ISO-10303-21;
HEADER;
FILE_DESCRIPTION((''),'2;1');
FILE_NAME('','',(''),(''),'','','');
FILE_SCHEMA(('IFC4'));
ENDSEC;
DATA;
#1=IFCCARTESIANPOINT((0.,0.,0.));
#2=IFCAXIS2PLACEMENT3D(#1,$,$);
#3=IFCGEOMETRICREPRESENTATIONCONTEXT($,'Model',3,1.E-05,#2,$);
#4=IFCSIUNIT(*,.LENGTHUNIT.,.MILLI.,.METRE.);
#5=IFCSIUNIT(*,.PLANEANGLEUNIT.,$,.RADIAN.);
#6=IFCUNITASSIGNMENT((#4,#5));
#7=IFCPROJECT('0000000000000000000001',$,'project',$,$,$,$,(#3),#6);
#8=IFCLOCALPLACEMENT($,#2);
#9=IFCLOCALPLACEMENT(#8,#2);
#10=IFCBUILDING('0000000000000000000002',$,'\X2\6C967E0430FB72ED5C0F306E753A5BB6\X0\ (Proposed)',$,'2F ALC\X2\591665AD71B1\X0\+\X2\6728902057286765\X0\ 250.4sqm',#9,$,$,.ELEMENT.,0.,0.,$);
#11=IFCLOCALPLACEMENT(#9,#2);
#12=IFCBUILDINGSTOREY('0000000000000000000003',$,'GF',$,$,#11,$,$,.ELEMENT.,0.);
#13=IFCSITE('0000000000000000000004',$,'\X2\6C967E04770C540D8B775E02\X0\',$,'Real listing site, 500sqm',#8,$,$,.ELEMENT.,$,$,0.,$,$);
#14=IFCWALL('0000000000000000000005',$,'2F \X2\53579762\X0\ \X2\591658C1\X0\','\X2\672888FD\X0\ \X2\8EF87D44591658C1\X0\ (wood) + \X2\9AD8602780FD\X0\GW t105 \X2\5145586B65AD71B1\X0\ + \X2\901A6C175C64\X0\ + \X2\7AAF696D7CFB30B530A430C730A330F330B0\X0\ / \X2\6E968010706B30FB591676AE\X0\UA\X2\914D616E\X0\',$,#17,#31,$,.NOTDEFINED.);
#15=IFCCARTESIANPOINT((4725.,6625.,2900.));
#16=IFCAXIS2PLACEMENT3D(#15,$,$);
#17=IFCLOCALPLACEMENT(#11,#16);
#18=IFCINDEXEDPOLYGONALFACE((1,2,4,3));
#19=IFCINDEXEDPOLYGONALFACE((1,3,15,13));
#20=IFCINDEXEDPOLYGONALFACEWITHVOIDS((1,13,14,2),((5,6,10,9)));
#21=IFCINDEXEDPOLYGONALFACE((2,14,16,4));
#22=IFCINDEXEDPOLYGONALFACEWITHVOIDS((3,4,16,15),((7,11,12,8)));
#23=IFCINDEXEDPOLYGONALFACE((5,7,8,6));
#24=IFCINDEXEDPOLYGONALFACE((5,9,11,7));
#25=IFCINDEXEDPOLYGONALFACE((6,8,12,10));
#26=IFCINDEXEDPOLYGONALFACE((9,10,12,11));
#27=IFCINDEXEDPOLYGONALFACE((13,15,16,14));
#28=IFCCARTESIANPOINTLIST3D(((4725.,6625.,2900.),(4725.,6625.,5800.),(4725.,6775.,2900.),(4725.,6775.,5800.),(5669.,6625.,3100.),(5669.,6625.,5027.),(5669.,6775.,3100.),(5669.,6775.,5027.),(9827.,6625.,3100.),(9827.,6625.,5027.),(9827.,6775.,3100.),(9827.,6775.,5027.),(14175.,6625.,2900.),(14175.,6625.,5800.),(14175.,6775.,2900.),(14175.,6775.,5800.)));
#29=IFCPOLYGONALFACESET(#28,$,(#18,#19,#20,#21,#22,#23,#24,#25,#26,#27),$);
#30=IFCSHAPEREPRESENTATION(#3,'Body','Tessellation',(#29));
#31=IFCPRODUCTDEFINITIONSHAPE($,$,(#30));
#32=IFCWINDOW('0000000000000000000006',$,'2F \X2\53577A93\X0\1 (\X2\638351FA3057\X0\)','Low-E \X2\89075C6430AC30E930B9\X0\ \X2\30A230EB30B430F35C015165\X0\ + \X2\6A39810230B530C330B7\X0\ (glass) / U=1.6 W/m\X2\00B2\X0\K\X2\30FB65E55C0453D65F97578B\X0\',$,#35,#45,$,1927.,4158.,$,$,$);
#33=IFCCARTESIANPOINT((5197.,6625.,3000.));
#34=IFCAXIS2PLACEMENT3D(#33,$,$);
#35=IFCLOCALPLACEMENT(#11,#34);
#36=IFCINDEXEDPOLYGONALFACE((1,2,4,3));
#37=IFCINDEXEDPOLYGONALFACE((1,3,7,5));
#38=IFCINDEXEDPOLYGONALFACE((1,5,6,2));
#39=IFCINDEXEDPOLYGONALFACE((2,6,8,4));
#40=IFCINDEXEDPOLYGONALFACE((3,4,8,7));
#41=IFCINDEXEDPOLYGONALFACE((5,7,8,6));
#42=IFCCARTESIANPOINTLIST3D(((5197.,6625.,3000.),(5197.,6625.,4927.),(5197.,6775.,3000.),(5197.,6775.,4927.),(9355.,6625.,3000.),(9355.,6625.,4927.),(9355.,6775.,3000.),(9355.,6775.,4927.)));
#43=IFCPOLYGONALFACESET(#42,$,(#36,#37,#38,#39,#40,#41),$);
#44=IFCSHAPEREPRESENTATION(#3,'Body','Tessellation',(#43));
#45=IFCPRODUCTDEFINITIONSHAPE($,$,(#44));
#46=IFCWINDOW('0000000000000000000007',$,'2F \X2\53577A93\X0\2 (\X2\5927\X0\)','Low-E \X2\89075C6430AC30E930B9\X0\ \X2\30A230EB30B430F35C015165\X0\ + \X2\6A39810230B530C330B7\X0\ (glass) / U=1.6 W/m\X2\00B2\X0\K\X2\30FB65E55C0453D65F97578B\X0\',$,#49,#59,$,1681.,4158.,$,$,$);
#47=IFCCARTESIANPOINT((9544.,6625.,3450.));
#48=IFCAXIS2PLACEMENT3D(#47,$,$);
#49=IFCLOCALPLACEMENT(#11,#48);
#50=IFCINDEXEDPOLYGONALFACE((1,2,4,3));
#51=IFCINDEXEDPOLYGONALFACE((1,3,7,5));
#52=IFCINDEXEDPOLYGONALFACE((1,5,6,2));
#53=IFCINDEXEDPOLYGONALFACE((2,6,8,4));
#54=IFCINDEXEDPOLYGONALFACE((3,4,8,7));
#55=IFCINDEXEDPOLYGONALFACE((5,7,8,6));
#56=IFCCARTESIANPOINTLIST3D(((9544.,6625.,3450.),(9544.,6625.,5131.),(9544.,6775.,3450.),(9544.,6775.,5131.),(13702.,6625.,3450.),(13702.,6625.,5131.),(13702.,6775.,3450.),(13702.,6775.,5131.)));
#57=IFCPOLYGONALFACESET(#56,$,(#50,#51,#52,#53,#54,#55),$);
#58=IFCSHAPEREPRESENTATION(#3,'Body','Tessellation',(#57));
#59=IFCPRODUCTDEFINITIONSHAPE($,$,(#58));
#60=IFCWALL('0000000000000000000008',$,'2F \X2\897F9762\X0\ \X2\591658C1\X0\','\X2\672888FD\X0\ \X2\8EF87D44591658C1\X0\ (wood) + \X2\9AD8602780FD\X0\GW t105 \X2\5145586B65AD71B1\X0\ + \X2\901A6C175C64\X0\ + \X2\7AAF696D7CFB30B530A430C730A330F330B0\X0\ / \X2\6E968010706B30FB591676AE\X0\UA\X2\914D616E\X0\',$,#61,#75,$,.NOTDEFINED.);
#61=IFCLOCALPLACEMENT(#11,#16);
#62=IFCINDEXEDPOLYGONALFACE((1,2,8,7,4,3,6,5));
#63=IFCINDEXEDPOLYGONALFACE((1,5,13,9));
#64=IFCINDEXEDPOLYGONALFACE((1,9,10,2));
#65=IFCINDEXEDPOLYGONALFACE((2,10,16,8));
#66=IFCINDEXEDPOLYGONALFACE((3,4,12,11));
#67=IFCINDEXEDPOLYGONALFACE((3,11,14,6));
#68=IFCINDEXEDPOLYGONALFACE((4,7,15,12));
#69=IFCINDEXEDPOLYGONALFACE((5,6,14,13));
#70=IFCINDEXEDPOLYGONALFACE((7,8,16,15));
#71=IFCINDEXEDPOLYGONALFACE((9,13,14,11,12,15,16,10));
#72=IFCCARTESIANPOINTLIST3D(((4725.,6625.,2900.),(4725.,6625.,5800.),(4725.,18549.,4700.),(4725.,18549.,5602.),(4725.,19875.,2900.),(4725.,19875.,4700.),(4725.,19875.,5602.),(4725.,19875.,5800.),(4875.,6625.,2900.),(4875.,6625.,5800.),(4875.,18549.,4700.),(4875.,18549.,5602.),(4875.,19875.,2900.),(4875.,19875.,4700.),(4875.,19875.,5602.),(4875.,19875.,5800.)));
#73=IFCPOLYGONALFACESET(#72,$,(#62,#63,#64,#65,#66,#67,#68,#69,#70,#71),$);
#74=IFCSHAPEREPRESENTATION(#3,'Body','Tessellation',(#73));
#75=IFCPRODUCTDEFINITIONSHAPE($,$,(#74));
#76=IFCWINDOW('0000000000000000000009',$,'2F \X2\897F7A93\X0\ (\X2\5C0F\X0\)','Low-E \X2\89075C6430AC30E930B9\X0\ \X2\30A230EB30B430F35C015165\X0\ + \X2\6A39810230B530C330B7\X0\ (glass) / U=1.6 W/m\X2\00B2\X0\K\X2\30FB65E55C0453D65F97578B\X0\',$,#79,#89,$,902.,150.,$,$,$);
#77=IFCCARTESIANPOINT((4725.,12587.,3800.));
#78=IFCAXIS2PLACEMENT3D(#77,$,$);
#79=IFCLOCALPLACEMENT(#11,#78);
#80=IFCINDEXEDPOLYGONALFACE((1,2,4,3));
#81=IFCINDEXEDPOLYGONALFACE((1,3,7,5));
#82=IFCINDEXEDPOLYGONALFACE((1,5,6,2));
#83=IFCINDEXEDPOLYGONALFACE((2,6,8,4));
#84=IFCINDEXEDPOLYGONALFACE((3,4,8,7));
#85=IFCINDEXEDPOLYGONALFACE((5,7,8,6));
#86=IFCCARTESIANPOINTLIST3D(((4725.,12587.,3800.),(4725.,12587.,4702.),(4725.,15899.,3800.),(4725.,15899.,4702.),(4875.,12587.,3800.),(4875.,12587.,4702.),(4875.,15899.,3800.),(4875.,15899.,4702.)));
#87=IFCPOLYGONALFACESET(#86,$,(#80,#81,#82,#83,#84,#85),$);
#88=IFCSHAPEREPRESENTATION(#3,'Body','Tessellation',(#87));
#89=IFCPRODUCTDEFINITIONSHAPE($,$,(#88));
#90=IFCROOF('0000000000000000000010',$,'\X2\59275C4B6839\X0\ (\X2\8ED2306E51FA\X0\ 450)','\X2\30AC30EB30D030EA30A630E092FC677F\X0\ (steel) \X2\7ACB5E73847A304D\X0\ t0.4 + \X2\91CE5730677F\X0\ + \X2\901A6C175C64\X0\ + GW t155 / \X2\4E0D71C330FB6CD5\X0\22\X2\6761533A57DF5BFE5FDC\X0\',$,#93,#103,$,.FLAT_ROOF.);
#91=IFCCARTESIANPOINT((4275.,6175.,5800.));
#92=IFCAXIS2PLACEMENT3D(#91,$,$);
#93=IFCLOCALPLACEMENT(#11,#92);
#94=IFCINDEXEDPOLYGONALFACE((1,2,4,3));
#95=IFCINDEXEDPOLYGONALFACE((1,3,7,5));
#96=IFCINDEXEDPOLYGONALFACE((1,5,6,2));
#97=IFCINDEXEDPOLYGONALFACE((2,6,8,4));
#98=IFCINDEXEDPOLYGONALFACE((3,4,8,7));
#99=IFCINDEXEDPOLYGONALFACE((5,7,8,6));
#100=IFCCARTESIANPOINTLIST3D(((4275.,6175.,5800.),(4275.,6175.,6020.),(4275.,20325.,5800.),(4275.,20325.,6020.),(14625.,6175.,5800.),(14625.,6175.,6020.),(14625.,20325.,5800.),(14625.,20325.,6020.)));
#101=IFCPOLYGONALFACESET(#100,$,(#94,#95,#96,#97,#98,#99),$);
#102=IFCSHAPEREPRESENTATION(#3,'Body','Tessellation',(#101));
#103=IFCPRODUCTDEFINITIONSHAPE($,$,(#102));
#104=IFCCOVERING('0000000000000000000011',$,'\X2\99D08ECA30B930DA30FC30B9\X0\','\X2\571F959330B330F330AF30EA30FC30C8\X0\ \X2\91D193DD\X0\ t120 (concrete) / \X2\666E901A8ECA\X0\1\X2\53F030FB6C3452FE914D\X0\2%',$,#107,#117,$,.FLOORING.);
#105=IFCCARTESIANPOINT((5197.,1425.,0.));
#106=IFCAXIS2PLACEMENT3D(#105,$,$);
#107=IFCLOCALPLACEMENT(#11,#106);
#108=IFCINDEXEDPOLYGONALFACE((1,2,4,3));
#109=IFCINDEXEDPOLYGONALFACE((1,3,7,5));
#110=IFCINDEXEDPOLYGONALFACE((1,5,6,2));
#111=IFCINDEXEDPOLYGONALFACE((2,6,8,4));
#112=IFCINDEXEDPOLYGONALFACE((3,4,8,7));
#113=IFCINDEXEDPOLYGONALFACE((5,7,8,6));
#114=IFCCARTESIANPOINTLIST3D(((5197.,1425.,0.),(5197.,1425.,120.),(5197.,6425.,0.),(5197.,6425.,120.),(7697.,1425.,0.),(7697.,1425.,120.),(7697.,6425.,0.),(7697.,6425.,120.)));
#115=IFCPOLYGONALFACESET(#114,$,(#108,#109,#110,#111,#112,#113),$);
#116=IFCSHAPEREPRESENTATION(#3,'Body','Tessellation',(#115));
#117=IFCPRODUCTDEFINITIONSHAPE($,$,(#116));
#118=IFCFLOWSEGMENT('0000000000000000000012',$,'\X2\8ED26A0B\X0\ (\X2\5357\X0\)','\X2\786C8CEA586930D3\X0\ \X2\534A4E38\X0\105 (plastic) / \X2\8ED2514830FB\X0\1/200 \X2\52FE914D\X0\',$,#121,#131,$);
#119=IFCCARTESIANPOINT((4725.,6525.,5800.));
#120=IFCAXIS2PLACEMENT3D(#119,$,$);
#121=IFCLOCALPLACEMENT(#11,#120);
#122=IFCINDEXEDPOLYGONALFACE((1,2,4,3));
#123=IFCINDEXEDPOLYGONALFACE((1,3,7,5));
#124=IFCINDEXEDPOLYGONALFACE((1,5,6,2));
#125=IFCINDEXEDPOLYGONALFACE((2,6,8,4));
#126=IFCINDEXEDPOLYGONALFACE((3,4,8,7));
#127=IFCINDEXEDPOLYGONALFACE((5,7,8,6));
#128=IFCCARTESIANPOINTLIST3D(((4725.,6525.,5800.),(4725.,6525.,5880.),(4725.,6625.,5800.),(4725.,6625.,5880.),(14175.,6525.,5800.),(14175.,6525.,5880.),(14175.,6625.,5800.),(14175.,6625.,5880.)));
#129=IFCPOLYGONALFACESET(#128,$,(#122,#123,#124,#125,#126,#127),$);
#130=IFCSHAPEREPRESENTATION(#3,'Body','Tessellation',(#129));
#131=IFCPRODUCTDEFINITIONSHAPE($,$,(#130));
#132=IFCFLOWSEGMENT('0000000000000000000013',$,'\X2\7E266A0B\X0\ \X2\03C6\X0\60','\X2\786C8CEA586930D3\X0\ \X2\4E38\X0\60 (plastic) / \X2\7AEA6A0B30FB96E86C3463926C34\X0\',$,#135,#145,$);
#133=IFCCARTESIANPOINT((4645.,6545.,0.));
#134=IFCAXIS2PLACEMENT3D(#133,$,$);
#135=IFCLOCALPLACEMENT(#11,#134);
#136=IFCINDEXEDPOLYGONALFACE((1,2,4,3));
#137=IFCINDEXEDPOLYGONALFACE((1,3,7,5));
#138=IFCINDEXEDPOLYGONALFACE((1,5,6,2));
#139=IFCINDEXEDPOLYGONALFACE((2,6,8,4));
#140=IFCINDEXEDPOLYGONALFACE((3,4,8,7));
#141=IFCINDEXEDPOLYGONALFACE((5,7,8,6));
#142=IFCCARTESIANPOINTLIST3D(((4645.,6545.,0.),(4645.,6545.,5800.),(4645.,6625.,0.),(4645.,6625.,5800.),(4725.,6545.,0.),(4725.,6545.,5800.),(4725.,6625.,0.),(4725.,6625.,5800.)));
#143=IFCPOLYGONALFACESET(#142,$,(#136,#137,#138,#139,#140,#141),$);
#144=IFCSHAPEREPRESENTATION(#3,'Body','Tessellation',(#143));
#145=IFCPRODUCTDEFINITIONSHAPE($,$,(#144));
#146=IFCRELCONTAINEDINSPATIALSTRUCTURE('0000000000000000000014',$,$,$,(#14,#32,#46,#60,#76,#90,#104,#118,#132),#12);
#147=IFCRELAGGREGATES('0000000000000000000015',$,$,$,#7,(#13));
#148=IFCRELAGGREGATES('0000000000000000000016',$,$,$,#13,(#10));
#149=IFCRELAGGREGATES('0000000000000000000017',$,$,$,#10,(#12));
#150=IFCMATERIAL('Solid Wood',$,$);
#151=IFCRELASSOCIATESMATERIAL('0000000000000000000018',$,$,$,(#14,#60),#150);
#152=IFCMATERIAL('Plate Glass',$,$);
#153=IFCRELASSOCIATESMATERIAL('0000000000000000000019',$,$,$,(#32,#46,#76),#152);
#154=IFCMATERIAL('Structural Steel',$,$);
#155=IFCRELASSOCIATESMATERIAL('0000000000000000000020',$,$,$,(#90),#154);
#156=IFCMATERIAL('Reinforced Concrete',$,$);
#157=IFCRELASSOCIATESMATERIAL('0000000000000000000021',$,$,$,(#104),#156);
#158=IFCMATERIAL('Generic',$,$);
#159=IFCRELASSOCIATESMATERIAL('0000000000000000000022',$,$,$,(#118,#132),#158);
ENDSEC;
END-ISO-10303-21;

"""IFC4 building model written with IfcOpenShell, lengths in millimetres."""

from ifc_helpers import new_model, si_unit, frame, frame_2d, origin, place, context, project, spatial, rectangle, extrude, material, element, fill, save


model = new_model("IFC4")

# Units and contexts
model_context = context("Model", 3, precision=1e-05, world=origin())
ifc_project = project(units=[si_unit("LENGTHUNIT", "METRE", prefix="MILLI"), si_unit("PLANEANGLEUNIT", "RADIAN")], contexts=[model_context])

# Site, building, storey
site_placement = place(None, origin())
site = spatial("IfcSite", under=ifc_project, at=site_placement, Name="沖縄県名護市", ObjectType="Real listing site, 500sqm", CompositionType="ELEMENT", RefElevation=0.0)
building_placement = place(site_placement, origin())
building = spatial("IfcBuilding", under=site, at=building_placement, Name="沖縄・狭小の町家 (Proposed)", ObjectType="2F ALC外断熱+木造在来 250.4sqm", CompositionType="ELEMENT", ElevationOfRefHeight=0.0, ElevationOfTerrain=0.0)
storey_placement = place(building_placement, origin())
storey = spatial("IfcBuildingStorey", under=building, at=storey_placement, Name="GF", CompositionType="ELEMENT", Elevation=0.0)

# Shared definitions
ifc_material_1 = material(Name="Solid Wood")

# Shared definitions
ifc_material_2 = material(Name="Reinforced Concrete")

# Shared definitions
ifc_material_3 = material(Name="Plate Glass")

# Wall, openings, windows
wall_1_placement = place(storey_placement, frame((4725.0, 6625.0, 2900.0)))
wall_1 = element("IfcWall", 1, at=wall_1_placement, inside=storey, material=ifc_material_1, Name="2F 南面 外壁", Description="木製 軸組外壁 (wood) + 高性能GW t105 充填断熱 + 通気層 + 窯業系サイディング / 準耐火・外皮UA配慮", PredefinedType="NOTDEFINED", context=model_context, shape_type="SweptSolid", body=[
    extrude(rectangle(XDim=9450.0, YDim=150.0, at=frame_2d((4725.0, 75.0))), frame((4725.0, 6625.0, 2900.0)), (0.0, 0.0, 1.0), 2900.0),
])
opening_1_placement = place(storey_placement, frame((5197.0, 6625.0, 3000.0)))
opening_1 = element("IfcOpeningElement", 2, at=opening_1_placement, cuts=wall_1, PredefinedType="NOTDEFINED", context=model_context, shape_type="SweptSolid", body=[
    extrude(rectangle(XDim=4158.0, YDim=150.0, at=frame_2d((2079.0, 75.0))), frame((5197.0, 6625.0, 3000.0)), (0.0, 0.0, 1.0), 1927.0),
])
opening_2_placement = place(storey_placement, frame((9544.0, 6625.0, 3450.0)))
opening_2 = element("IfcOpeningElement", 3, at=opening_2_placement, cuts=wall_1, PredefinedType="NOTDEFINED", context=model_context, shape_type="SweptSolid", body=[
    extrude(rectangle(XDim=4158.0, YDim=150.0, at=frame_2d((2079.0, 75.0))), frame((9544.0, 6625.0, 3450.0)), (0.0, 0.0, 1.0), 1681.0),
])
window_1_placement = place(storey_placement, frame((5197.0, 6625.0, 3000.0)))
window_1 = element("IfcWindow", 4, at=window_1_placement, inside=storey, material=ifc_material_3, Name="2F 南窓1 (掃出し)", Description="Low-E 複層ガラス アルゴン封入 + 樹脂サッシ (glass) / U=1.6 W/m²K・日射取得型", OverallHeight=1927.0, OverallWidth=4158.0, context=model_context, shape_type="SweptSolid", body=[
    extrude(rectangle(XDim=4158.0, YDim=150.0, at=frame_2d((2079.0, 75.0))), frame((5197.0, 6625.0, 3000.0)), (0.0, 0.0, 1.0), 1927.0),
])
fill(opening_1, window_1)
window_2_placement = place(storey_placement, frame((9544.0, 6625.0, 3450.0)))
window_2 = element("IfcWindow", 5, at=window_2_placement, inside=storey, material=ifc_material_3, Name="2F 南窓2 (大)", Description="Low-E 複層ガラス アルゴン封入 + 樹脂サッシ (glass) / U=1.6 W/m²K・日射取得型", OverallHeight=1681.0, OverallWidth=4158.0, context=model_context, shape_type="SweptSolid", body=[
    extrude(rectangle(XDim=4158.0, YDim=150.0, at=frame_2d((2079.0, 75.0))), frame((9544.0, 6625.0, 3450.0)), (0.0, 0.0, 1.0), 1681.0),
])
fill(opening_2, window_2)

# Wall, opening, window
wall_2_placement = place(storey_placement, frame((4725.0, 6625.0, 2900.0)))
wall_2 = element("IfcWall", 6, at=wall_2_placement, inside=storey, material=ifc_material_1, Name="2F 西面 外壁", Description="木製 軸組外壁 (wood) + 高性能GW t105 充填断熱 + 通気層 + 窯業系サイディング / 準耐火・外皮UA配慮", PredefinedType="NOTDEFINED", context=model_context, shape_type="SweptSolid", body=[
    extrude(rectangle(XDim=150.0, YDim=13250.0, at=frame_2d((75.0, 6625.0))), frame((4725.0, 6625.0, 2900.0)), (0.0, 0.0, 1.0), 2900.0),
])
opening_3_placement = place(storey_placement, frame((4725.0, 12587.0, 3800.0)))
opening_3 = element("IfcOpeningElement", 7, at=opening_3_placement, cuts=wall_2, PredefinedType="NOTDEFINED", context=model_context, shape_type="SweptSolid", body=[
    extrude(rectangle(XDim=150.0, YDim=3312.0, at=frame_2d((75.0, 1656.0))), frame((4725.0, 12587.0, 3800.0)), (0.0, 0.0, 1.0), 902.0),
])
window_3_placement = place(storey_placement, frame((4725.0, 12587.0, 3800.0)))
window_3 = element("IfcWindow", 8, at=window_3_placement, inside=storey, material=ifc_material_3, Name="2F 西窓 (小)", Description="Low-E 複層ガラス アルゴン封入 + 樹脂サッシ (glass) / U=1.6 W/m²K・日射取得型", OverallHeight=902.0, OverallWidth=150.0, context=model_context, shape_type="SweptSolid", body=[
    extrude(rectangle(XDim=150.0, YDim=3312.0, at=frame_2d((75.0, 1656.0))), frame((4725.0, 12587.0, 3800.0)), (0.0, 0.0, 1.0), 902.0),
])
fill(opening_3, window_3)

# Roof
ifc_material_4 = material(Name="Structural Steel")
roof_placement = place(storey_placement, frame((4275.0, 6175.0, 5800.0)))
element("IfcRoof", 9, at=roof_placement, inside=storey, material=ifc_material_4, Name="大屋根 (軒の出 450)", Description="ガルバリウム鋼板 (steel) 立平葺き t0.4 + 野地板 + 通気層 + GW t155 / 不燃・法22条区域対応", PredefinedType="FLAT_ROOF", context=model_context, shape_type="SweptSolid", body=[
    extrude(rectangle(XDim=10350.0, YDim=14150.0, at=frame_2d((5175.0, 7075.0))), frame((4275.0, 6175.0, 5800.0)), (0.0, 0.0, 1.0), 220.0),
])

# Covering
covering_placement = place(storey_placement, frame((5197.0, 1425.0, 0.0)))
element("IfcCovering", 10, at=covering_placement, inside=storey, material=ifc_material_2, Name="駐車スペース", Description="土間コンクリート 金鏝 t120 (concrete) / 普通車1台・水勾配2%", PredefinedType="FLOORING", context=model_context, shape_type="SweptSolid", body=[
    extrude(rectangle(XDim=2500.0, YDim=5000.0, at=frame_2d((1250.0, 2500.0))), frame((5197.0, 1425.0, 0.0)), (0.0, 0.0, 1.0), 120.0),
])

# Flow segments
ifc_material_5 = material(Name="Generic")
flow_segment_1_placement = place(storey_placement, frame((4725.0, 6525.0, 5800.0)))
element("IfcFlowSegment", 11, at=flow_segment_1_placement, inside=storey, material=ifc_material_5, Name="軒樋 (南)", Description="硬質塩ビ 半丸105 (plastic) / 軒先・1/200 勾配", context=model_context, shape_type="SweptSolid", body=[
    extrude(rectangle(XDim=9450.0, YDim=100.0, at=frame_2d((4725.0, 50.0))), frame((4725.0, 6525.0, 5800.0)), (0.0, 0.0, 1.0), 80.0),
])
flow_segment_2_placement = place(storey_placement, frame((4645.0, 6545.0, 0.0)))
element("IfcFlowSegment", 12, at=flow_segment_2_placement, inside=storey, material=ifc_material_5, Name="縦樋 φ60", Description="硬質塩ビ 丸60 (plastic) / 竪樋・雨水排水", context=model_context, shape_type="SweptSolid", body=[
    extrude(rectangle(XDim=80.0, YDim=80.0, at=frame_2d((40.0, 40.0))), frame((4645.0, 6545.0, 0.0)), (0.0, 0.0, 1.0), 5800.0),
])

save(model, "model.ifc")
